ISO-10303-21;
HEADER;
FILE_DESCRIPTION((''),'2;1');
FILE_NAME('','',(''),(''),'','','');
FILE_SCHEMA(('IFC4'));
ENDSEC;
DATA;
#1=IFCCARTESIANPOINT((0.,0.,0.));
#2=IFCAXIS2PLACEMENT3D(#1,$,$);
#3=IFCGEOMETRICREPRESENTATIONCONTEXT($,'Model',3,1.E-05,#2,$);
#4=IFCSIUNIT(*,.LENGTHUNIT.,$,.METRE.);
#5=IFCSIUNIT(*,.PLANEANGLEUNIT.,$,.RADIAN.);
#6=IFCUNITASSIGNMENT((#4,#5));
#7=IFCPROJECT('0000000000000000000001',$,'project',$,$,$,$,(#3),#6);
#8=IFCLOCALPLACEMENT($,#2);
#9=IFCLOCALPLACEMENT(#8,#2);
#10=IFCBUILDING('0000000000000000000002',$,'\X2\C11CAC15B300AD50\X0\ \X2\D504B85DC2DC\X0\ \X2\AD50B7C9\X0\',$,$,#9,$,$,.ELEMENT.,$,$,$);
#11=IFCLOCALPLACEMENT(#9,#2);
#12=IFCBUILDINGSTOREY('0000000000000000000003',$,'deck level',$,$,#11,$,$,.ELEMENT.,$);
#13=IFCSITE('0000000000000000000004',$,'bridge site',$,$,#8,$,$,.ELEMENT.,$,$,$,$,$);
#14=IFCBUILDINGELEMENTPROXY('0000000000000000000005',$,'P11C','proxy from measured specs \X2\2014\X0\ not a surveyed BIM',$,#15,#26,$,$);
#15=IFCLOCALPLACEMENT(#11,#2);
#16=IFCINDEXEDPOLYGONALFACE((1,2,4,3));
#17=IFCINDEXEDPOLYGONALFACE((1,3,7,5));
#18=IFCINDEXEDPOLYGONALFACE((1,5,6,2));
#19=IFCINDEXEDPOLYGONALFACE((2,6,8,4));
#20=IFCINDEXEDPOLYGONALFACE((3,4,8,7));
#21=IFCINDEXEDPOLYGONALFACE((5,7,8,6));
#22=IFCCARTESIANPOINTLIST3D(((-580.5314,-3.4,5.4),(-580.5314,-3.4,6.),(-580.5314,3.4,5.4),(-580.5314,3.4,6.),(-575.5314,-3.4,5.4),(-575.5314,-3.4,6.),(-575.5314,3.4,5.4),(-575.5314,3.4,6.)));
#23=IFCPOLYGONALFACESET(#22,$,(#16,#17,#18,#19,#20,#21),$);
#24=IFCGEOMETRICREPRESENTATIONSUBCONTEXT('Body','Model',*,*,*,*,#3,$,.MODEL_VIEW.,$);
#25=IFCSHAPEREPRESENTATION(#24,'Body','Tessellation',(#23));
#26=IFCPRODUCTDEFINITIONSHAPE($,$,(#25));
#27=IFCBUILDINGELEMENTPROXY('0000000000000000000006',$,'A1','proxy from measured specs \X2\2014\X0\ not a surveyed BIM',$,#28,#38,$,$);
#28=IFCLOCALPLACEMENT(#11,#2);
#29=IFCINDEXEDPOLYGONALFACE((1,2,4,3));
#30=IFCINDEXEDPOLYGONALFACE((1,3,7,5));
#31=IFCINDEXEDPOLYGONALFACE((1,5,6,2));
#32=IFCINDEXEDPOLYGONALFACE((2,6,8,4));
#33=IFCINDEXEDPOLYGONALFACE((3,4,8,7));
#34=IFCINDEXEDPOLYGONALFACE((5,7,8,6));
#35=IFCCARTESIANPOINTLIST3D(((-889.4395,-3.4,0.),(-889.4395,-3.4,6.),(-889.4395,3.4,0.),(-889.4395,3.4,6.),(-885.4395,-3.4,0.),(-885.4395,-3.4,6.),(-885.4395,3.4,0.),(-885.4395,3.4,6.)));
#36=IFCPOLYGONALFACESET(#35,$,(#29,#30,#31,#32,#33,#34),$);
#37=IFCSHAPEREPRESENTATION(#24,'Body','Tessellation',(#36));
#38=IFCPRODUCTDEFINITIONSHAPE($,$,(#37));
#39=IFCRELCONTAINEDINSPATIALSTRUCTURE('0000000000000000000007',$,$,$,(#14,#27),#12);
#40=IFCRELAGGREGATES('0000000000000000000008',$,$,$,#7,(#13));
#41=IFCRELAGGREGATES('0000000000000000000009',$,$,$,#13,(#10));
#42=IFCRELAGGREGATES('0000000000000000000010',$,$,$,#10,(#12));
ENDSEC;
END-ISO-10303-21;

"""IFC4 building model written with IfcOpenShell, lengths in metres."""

from ifc_helpers import new_model, si_unit, frame, origin, origin_2d, place, context, subcontext, project, spatial, rectangle, extrude, element, save


model = new_model("IFC4")

# Units and contexts
model_context = context("Model", 3, precision=1e-05, world=origin())
body_context = subcontext(model_context, "Body", "Model", "MODEL_VIEW")
ifc_project = project(units=[si_unit("LENGTHUNIT", "METRE"), si_unit("PLANEANGLEUNIT", "RADIAN")], contexts=[model_context])

# Site, building, storey
site_placement = place(None, origin())
site = spatial("IfcSite", under=ifc_project, at=site_placement, Name="bridge site", CompositionType="ELEMENT")
building_placement = place(site_placement, origin())
building = spatial("IfcBuilding", under=site, at=building_placement, Name="서강대교 프록시 교량", CompositionType="ELEMENT")
storey_placement = place(building_placement, origin())
storey = spatial("IfcBuildingStorey", under=building, at=storey_placement, Name="deck level", CompositionType="ELEMENT")

# Building element proxies
for number, where, name in (
    (1, (-578.0314, 0.0, 5.4), "P11C"),
):
    element("IfcBuildingElementProxy", number, at=place(storey_placement, frame(where)), inside=storey, Name=name, Description="proxy from measured specs — not a surveyed BIM", context=body_context, shape_type="SweptSolid", body=[
        extrude(rectangle(XDim=5.0, YDim=6.8, at=origin_2d()), origin(), (0.0, 0.0, 1.0), 0.6),
    ])
proxy_placement = place(storey_placement, frame((-887.4395, 0.0, 0.0)))
element("IfcBuildingElementProxy", 2, at=proxy_placement, inside=storey, Name="A1", Description="proxy from measured specs — not a surveyed BIM", context=body_context, shape_type="SweptSolid", body=[
    extrude(rectangle(XDim=4.0, YDim=6.8, at=origin_2d()), origin(), (0.0, 0.0, 1.0), 6.0),
])

save(model, "model.ifc")
